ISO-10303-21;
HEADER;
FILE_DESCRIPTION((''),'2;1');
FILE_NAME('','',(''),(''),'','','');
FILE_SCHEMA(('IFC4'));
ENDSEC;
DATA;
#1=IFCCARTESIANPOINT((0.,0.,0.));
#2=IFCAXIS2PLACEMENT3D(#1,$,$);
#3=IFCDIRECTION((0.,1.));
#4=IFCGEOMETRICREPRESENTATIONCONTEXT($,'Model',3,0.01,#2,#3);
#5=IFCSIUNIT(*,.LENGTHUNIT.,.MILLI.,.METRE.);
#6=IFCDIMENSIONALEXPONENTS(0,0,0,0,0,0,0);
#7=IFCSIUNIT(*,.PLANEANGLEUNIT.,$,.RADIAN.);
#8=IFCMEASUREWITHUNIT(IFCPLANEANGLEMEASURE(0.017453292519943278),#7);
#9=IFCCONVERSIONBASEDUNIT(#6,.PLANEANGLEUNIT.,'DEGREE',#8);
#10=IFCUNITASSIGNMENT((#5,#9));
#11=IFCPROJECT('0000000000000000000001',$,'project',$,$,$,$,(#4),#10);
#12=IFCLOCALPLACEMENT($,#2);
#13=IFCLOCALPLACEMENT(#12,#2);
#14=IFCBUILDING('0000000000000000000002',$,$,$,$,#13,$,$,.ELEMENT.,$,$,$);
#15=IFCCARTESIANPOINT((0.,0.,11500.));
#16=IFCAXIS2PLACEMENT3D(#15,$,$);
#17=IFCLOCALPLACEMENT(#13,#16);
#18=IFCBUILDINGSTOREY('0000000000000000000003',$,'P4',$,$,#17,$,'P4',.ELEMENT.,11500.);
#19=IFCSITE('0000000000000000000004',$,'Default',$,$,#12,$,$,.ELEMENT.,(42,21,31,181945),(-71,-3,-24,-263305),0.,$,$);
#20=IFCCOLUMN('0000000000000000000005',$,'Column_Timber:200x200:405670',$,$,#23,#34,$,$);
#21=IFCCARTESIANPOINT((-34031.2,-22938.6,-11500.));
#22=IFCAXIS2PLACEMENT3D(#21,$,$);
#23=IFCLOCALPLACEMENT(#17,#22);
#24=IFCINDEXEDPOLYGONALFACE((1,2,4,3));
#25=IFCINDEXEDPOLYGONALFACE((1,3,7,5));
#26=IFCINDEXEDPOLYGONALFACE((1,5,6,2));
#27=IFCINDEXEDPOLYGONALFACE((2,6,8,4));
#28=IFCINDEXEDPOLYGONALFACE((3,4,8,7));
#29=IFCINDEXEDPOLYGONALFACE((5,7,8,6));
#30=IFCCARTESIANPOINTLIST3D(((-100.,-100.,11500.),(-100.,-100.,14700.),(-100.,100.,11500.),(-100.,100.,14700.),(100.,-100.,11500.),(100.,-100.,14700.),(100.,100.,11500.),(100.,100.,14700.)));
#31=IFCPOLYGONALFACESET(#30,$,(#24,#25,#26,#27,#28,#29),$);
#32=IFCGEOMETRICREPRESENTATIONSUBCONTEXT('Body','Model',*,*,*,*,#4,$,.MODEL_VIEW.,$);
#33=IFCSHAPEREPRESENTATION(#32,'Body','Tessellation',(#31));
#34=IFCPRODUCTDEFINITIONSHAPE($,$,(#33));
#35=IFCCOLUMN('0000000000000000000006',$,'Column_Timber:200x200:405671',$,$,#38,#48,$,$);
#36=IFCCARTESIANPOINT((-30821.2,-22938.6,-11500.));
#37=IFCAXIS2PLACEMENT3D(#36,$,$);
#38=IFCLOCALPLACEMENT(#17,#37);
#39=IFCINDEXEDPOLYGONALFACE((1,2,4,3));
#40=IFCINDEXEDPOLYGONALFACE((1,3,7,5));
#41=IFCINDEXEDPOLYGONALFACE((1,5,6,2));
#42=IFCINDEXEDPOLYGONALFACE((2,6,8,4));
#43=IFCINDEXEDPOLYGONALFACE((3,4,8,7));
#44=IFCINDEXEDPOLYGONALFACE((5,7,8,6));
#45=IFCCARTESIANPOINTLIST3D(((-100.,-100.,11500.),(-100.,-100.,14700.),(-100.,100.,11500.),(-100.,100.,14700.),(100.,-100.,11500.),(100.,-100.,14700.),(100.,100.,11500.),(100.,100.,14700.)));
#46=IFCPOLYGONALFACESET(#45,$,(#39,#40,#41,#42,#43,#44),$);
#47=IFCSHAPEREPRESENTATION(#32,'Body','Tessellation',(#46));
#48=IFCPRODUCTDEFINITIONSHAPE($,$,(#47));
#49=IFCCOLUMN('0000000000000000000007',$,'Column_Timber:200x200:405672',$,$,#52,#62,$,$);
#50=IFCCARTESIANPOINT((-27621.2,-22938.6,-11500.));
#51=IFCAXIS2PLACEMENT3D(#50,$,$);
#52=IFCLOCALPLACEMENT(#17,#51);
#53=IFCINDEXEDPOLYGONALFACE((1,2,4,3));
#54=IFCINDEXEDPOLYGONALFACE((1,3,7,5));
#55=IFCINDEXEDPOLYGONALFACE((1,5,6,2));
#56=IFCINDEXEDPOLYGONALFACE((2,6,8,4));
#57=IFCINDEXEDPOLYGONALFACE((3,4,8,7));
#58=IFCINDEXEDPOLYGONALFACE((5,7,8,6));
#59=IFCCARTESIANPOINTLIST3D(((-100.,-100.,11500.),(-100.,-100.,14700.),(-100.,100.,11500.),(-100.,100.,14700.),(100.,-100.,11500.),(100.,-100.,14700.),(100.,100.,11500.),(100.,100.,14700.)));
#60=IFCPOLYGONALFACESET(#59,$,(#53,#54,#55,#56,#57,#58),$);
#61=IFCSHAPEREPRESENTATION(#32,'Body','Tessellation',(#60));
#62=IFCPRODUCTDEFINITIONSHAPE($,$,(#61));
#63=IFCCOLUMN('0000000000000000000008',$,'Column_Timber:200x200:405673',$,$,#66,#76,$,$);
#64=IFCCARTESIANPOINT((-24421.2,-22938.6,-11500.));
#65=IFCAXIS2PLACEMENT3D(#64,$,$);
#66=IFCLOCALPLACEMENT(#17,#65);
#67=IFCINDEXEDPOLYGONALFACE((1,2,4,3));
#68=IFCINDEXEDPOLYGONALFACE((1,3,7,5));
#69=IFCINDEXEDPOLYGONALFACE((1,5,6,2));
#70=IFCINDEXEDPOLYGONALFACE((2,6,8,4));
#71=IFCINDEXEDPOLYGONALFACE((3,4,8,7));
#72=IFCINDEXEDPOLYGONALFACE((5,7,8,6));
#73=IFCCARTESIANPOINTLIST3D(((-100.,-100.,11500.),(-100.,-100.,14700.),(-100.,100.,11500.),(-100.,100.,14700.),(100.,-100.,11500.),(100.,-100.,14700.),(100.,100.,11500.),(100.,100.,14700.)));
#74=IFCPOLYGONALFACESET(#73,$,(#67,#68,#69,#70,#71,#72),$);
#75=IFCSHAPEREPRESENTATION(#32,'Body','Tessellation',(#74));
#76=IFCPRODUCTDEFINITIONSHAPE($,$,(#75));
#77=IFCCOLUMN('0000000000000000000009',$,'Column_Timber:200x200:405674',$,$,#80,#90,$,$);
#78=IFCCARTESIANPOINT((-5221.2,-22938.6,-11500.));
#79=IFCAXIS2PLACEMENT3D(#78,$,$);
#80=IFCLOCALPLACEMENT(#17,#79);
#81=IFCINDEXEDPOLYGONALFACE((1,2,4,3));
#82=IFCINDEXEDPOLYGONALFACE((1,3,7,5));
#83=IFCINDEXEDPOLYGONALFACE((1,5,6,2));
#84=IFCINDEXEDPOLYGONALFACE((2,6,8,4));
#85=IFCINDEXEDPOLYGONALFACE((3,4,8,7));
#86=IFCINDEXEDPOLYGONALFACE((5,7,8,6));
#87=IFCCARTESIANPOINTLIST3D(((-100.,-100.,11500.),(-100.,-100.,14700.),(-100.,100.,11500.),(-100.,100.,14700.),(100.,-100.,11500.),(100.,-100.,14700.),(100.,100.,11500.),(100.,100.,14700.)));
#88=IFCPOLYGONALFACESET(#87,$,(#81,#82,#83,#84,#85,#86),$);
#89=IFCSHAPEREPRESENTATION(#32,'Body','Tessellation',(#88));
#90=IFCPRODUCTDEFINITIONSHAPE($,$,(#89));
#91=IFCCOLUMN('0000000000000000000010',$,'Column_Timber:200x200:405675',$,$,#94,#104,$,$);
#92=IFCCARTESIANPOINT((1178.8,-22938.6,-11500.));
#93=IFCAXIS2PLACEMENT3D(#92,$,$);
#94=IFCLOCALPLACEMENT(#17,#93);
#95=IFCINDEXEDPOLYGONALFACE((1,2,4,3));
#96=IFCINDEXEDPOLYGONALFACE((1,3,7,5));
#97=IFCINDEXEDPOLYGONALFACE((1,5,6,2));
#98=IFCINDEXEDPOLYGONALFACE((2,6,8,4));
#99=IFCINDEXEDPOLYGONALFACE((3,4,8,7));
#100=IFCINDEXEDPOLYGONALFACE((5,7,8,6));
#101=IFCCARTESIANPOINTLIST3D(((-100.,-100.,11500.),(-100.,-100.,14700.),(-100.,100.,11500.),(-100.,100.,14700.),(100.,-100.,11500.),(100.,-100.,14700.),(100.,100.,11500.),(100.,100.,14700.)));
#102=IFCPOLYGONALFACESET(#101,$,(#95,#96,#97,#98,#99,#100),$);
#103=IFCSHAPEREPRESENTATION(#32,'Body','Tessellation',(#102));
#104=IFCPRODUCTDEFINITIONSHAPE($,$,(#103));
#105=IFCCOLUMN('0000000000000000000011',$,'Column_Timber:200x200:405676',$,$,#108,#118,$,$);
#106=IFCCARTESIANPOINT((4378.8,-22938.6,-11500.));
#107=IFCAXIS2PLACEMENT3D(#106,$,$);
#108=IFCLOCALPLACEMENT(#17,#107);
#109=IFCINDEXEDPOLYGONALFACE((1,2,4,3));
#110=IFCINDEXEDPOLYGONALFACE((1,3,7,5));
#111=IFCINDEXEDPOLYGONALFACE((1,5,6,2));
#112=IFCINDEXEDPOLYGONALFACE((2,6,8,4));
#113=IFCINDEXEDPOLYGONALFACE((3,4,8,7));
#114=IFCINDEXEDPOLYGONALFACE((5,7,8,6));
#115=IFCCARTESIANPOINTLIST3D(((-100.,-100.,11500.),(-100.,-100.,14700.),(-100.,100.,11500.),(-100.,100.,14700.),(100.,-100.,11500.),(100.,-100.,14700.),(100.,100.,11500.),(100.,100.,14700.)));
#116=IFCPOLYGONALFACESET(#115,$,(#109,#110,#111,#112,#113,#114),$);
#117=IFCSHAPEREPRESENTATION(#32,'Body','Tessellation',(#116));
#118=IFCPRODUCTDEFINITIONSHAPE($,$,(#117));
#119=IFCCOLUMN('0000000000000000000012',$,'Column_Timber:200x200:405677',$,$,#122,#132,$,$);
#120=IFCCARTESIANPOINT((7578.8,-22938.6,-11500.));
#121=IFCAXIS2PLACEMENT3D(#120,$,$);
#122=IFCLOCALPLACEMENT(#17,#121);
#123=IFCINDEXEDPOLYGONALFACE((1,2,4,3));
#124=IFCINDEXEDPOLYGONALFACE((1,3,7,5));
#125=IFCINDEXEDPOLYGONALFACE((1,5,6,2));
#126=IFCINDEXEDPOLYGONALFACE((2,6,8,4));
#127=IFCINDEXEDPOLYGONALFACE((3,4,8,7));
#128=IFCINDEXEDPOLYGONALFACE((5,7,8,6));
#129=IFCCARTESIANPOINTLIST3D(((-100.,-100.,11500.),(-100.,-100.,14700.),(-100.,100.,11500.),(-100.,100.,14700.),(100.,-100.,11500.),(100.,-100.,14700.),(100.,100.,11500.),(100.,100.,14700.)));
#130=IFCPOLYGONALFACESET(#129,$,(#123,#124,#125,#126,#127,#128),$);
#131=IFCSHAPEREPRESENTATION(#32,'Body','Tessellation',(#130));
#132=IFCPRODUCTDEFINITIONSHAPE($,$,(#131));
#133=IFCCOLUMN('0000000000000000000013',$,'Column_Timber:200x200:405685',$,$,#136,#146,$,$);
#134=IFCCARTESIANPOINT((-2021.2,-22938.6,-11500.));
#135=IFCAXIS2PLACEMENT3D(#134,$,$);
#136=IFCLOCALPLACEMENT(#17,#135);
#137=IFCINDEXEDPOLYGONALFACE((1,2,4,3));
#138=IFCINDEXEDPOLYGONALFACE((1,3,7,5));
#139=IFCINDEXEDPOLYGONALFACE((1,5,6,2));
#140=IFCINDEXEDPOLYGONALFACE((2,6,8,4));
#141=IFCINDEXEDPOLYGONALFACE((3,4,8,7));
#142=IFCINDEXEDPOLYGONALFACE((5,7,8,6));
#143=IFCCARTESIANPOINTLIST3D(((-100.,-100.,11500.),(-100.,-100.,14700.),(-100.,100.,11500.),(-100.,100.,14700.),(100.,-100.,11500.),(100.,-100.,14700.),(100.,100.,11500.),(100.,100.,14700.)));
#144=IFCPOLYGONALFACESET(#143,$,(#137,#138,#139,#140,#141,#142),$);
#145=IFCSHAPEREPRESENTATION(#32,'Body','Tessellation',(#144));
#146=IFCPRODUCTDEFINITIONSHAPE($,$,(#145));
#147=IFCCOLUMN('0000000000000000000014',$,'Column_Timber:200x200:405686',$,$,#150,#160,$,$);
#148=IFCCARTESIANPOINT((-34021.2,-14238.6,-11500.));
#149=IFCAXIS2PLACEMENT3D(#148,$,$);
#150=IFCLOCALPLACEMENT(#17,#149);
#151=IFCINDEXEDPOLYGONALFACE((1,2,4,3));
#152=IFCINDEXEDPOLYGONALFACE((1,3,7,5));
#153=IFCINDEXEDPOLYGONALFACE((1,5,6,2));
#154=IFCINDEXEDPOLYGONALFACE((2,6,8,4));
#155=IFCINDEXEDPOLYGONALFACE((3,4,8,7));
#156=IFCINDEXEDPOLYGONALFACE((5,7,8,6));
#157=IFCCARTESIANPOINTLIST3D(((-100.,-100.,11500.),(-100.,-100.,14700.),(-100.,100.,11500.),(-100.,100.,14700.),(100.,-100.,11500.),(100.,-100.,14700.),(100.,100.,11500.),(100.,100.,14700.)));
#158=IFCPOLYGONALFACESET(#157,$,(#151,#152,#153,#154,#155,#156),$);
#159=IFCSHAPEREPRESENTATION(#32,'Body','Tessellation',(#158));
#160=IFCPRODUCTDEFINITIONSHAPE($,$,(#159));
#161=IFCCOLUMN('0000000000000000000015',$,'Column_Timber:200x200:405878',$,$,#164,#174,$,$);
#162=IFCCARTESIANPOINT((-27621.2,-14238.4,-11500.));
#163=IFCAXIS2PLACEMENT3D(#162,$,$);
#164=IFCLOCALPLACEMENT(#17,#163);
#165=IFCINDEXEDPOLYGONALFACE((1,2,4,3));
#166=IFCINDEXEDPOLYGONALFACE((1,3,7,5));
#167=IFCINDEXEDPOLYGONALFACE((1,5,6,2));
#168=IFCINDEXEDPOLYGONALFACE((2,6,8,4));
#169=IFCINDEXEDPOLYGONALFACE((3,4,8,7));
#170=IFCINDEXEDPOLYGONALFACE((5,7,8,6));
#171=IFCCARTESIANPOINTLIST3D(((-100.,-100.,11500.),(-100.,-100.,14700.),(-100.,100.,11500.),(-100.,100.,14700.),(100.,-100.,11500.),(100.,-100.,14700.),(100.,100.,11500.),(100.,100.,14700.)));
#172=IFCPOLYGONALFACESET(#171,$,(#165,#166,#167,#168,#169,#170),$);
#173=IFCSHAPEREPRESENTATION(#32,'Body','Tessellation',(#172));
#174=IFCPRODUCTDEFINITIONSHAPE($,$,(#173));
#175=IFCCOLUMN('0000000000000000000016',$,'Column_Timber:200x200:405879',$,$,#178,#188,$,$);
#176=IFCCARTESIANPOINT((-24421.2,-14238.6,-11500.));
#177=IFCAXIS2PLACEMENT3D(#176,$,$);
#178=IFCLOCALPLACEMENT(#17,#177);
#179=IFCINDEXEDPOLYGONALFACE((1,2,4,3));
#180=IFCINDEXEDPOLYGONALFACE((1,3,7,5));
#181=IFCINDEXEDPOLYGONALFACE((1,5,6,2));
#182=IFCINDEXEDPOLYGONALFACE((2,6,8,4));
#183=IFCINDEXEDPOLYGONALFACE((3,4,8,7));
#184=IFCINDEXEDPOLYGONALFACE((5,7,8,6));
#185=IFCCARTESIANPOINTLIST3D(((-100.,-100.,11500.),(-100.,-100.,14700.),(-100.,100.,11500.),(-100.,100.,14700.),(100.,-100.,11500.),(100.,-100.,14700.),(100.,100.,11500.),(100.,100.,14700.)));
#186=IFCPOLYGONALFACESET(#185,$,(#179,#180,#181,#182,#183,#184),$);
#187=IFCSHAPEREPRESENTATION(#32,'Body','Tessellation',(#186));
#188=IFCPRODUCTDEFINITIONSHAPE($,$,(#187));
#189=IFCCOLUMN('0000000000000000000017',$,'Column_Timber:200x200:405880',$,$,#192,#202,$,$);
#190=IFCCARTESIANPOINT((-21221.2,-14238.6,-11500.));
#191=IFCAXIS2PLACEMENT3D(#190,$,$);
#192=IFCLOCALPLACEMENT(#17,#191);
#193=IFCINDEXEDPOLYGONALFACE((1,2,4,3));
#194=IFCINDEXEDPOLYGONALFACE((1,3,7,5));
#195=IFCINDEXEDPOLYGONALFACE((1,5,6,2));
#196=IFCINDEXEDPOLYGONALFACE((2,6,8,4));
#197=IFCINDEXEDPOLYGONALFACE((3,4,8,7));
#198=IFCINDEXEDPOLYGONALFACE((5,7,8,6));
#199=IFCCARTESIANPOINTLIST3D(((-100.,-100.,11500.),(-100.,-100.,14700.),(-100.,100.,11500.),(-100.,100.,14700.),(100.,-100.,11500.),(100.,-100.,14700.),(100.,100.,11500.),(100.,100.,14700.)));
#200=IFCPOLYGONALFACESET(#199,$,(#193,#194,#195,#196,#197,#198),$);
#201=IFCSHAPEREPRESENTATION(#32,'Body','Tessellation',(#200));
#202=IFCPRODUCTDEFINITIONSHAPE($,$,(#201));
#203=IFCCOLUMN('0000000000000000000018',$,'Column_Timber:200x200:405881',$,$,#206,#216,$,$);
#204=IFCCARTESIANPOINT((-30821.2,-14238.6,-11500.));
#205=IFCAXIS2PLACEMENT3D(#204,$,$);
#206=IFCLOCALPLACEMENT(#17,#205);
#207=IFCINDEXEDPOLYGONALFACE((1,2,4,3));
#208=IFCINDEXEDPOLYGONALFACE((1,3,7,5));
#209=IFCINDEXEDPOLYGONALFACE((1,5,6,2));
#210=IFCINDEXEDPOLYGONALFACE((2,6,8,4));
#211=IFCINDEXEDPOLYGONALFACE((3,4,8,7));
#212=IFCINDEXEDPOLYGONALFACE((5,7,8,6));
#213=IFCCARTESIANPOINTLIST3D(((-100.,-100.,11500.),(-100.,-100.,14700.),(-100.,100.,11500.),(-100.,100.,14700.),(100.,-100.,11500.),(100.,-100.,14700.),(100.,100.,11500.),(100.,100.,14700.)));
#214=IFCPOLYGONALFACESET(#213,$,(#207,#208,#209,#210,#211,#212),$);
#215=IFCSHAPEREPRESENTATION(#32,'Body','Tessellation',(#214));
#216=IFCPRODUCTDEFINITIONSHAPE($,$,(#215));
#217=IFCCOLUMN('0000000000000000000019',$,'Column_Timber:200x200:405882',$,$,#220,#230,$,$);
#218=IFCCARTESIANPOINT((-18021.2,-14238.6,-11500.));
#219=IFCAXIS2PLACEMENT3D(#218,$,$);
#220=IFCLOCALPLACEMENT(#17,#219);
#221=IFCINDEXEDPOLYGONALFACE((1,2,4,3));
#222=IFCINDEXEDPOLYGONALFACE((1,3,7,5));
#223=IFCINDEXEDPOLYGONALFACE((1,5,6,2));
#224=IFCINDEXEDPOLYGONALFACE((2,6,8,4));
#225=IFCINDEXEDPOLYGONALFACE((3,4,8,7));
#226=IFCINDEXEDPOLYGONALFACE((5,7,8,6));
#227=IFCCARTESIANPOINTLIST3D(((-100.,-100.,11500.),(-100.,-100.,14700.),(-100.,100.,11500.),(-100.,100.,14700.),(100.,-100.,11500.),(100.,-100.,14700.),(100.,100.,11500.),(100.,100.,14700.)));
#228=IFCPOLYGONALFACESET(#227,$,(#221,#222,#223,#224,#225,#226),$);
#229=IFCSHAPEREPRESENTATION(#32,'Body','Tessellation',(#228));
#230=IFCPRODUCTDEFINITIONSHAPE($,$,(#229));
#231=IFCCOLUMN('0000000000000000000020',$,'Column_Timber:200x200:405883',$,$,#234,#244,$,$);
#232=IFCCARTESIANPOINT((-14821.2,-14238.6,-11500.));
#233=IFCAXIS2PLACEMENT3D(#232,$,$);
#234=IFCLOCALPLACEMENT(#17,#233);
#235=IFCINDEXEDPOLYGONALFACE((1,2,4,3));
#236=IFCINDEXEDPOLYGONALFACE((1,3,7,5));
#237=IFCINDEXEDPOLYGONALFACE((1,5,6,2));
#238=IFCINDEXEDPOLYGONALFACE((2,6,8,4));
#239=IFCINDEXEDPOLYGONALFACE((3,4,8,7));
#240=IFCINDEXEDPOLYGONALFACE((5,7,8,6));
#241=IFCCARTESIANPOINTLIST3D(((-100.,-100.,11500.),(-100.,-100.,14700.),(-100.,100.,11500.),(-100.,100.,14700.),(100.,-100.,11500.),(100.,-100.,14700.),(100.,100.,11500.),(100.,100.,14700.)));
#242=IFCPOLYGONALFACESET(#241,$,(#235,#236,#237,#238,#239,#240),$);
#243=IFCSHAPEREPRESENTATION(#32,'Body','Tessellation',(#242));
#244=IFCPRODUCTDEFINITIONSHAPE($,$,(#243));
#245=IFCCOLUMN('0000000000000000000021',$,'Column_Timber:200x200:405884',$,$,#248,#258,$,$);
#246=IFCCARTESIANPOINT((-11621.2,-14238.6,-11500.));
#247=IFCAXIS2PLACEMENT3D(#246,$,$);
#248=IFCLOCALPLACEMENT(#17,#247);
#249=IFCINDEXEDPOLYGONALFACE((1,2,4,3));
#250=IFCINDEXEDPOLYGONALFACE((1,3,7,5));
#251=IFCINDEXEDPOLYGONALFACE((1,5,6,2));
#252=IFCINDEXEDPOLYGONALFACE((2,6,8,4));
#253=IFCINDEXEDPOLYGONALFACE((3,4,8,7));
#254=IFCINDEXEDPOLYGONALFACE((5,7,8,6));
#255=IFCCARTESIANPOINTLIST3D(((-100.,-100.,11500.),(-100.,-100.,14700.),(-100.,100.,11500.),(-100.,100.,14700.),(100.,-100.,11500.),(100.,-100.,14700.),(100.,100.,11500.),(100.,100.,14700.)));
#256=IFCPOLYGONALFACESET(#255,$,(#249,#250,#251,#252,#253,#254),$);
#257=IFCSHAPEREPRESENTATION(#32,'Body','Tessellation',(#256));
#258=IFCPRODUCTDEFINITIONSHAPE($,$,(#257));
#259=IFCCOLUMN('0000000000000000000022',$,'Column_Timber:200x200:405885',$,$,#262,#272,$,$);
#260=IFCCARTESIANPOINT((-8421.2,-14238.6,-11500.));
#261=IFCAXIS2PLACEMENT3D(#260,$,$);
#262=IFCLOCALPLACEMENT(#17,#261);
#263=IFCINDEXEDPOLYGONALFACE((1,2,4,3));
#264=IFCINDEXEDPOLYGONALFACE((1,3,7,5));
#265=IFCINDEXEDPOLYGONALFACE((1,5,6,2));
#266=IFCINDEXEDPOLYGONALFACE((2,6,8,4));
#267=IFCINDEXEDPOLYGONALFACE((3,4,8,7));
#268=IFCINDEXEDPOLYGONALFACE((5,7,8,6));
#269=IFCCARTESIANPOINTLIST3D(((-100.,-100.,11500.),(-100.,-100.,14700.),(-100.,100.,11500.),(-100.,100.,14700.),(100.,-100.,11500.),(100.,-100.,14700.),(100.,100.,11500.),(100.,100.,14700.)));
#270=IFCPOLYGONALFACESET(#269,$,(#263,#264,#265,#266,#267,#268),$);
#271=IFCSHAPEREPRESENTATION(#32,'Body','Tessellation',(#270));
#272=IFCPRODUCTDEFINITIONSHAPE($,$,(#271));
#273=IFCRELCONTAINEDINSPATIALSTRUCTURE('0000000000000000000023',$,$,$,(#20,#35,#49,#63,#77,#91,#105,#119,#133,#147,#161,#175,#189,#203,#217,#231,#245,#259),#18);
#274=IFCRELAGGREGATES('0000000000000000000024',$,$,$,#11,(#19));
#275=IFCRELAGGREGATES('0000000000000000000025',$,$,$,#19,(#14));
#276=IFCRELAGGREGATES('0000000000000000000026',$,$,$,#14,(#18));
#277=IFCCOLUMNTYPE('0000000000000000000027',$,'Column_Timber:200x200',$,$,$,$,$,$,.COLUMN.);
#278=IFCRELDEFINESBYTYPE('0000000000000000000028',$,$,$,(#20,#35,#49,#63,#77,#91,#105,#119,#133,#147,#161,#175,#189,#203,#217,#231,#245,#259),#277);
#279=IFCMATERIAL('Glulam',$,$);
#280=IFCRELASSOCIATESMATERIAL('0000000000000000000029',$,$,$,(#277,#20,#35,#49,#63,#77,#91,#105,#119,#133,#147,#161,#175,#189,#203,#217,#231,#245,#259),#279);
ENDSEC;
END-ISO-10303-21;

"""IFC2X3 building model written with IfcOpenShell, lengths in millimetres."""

from ifc_helpers import new_model, entity, si_unit, converted_unit, direction, frame, frame_2d, origin, place, context, subcontext, project, spatial, rectangle, extrude, source, transform, mapped, material, type_object, type_shapes, element, save


model = new_model("IFC2X3")

# Units and contexts
model_context = context("Model", 3, precision=0.01, world=origin(), true_north=direction((0.0, 1.0)))
body_context = subcontext(model_context, "Body", "Model", "MODEL_VIEW")
ifc_project = project(units=[si_unit("LENGTHUNIT", "METRE", prefix="MILLI"), converted_unit("PLANEANGLEUNIT", "DEGREE", entity("IfcPlaneAngleMeasure", 0.017453292519943278), si_unit("PLANEANGLEUNIT", "RADIAN"), dimensions=[0, 0, 0, 0, 0, 0, 0])], contexts=[model_context])

# Site, building, storey
site_placement = place(None, origin())
site = spatial("IfcSite", under=ifc_project, at=site_placement, Name="Default", CompositionType="ELEMENT", RefLatitude=(42, 21, 31, 181945), RefLongitude=(-71, -3, -24, -263305), RefElevation=0.0)
building_placement = place(site_placement, origin())
building = spatial("IfcBuilding", under=site, at=building_placement, CompositionType="ELEMENT")
storey_placement = place(building_placement, frame((0.0, 0.0, 11500.0)))
storey = spatial("IfcBuildingStorey", under=building, at=storey_placement, Name="P4", LongName="P4", CompositionType="ELEMENT", Elevation=11500.0)

# Columns
ifc_material_1 = material(Name="Glulam")
column_type = type_object("IfcColumnType", Name="Column_Timber:200x200", PredefinedType="COLUMN", material=ifc_material_1)
shared_shape = source(origin(), body_context, "Body", "SweptSolid", [
    extrude(rectangle(XDim=200.0, YDim=200.0, at=frame_2d((0.0, 0.0), x_axis=(1.0, 0.0))), frame((0.0, 0.0, 11500.0), z_axis=(0.0, 0.0, 1.0), x_axis=(-1.0, 0.0, 0.0)), (0.0, 0.0, 1.0), 3200.0),
])
type_shapes(column_type, [shared_shape])
for number, where, name in (
    (1, (-34031.2, -22938.6, -11500.0), "Column_Timber:200x200:405670"),
    (2, (-30821.2, -22938.6, -11500.0), "Column_Timber:200x200:405671"),
    (3, (-27621.2, -22938.6, -11500.0), "Column_Timber:200x200:405672"),
    (4, (-24421.2, -22938.6, -11500.0), "Column_Timber:200x200:405673"),
    (5, (-5221.2, -22938.6, -11500.0), "Column_Timber:200x200:405674"),
    (6, (1178.8, -22938.6, -11500.0), "Column_Timber:200x200:405675"),
    (7, (4378.8, -22938.6, -11500.0), "Column_Timber:200x200:405676"),
    (8, (7578.8, -22938.6, -11500.0), "Column_Timber:200x200:405677"),
    (9, (-2021.2, -22938.6, -11500.0), "Column_Timber:200x200:405685"),
    (10, (-34021.2, -14238.6, -11500.0), "Column_Timber:200x200:405686"),
    (11, (-27621.2, -14238.4, -11500.0), "Column_Timber:200x200:405878"),
    (12, (-24421.2, -14238.6, -11500.0), "Column_Timber:200x200:405879"),
    (13, (-21221.2, -14238.6, -11500.0), "Column_Timber:200x200:405880"),
    (14, (-30821.2, -14238.6, -11500.0), "Column_Timber:200x200:405881"),
    (15, (-18021.2, -14238.6, -11500.0), "Column_Timber:200x200:405882"),
    (16, (-14821.2, -14238.6, -11500.0), "Column_Timber:200x200:405883"),
    (17, (-11621.2, -14238.6, -11500.0), "Column_Timber:200x200:405884"),
    (18, (-8421.2, -14238.6, -11500.0), "Column_Timber:200x200:405885"),
):
    element("IfcColumn", number, at=place(storey_placement, frame(where)), inside=storey, type_object=column_type, material=ifc_material_1, Name=name, context=body_context, shape_type="MappedRepresentation", body=[
        mapped(shared_shape, transform((0.0, 0.0, 0.0), scale=1.0)),
    ])

save(model, "model.ifc")
